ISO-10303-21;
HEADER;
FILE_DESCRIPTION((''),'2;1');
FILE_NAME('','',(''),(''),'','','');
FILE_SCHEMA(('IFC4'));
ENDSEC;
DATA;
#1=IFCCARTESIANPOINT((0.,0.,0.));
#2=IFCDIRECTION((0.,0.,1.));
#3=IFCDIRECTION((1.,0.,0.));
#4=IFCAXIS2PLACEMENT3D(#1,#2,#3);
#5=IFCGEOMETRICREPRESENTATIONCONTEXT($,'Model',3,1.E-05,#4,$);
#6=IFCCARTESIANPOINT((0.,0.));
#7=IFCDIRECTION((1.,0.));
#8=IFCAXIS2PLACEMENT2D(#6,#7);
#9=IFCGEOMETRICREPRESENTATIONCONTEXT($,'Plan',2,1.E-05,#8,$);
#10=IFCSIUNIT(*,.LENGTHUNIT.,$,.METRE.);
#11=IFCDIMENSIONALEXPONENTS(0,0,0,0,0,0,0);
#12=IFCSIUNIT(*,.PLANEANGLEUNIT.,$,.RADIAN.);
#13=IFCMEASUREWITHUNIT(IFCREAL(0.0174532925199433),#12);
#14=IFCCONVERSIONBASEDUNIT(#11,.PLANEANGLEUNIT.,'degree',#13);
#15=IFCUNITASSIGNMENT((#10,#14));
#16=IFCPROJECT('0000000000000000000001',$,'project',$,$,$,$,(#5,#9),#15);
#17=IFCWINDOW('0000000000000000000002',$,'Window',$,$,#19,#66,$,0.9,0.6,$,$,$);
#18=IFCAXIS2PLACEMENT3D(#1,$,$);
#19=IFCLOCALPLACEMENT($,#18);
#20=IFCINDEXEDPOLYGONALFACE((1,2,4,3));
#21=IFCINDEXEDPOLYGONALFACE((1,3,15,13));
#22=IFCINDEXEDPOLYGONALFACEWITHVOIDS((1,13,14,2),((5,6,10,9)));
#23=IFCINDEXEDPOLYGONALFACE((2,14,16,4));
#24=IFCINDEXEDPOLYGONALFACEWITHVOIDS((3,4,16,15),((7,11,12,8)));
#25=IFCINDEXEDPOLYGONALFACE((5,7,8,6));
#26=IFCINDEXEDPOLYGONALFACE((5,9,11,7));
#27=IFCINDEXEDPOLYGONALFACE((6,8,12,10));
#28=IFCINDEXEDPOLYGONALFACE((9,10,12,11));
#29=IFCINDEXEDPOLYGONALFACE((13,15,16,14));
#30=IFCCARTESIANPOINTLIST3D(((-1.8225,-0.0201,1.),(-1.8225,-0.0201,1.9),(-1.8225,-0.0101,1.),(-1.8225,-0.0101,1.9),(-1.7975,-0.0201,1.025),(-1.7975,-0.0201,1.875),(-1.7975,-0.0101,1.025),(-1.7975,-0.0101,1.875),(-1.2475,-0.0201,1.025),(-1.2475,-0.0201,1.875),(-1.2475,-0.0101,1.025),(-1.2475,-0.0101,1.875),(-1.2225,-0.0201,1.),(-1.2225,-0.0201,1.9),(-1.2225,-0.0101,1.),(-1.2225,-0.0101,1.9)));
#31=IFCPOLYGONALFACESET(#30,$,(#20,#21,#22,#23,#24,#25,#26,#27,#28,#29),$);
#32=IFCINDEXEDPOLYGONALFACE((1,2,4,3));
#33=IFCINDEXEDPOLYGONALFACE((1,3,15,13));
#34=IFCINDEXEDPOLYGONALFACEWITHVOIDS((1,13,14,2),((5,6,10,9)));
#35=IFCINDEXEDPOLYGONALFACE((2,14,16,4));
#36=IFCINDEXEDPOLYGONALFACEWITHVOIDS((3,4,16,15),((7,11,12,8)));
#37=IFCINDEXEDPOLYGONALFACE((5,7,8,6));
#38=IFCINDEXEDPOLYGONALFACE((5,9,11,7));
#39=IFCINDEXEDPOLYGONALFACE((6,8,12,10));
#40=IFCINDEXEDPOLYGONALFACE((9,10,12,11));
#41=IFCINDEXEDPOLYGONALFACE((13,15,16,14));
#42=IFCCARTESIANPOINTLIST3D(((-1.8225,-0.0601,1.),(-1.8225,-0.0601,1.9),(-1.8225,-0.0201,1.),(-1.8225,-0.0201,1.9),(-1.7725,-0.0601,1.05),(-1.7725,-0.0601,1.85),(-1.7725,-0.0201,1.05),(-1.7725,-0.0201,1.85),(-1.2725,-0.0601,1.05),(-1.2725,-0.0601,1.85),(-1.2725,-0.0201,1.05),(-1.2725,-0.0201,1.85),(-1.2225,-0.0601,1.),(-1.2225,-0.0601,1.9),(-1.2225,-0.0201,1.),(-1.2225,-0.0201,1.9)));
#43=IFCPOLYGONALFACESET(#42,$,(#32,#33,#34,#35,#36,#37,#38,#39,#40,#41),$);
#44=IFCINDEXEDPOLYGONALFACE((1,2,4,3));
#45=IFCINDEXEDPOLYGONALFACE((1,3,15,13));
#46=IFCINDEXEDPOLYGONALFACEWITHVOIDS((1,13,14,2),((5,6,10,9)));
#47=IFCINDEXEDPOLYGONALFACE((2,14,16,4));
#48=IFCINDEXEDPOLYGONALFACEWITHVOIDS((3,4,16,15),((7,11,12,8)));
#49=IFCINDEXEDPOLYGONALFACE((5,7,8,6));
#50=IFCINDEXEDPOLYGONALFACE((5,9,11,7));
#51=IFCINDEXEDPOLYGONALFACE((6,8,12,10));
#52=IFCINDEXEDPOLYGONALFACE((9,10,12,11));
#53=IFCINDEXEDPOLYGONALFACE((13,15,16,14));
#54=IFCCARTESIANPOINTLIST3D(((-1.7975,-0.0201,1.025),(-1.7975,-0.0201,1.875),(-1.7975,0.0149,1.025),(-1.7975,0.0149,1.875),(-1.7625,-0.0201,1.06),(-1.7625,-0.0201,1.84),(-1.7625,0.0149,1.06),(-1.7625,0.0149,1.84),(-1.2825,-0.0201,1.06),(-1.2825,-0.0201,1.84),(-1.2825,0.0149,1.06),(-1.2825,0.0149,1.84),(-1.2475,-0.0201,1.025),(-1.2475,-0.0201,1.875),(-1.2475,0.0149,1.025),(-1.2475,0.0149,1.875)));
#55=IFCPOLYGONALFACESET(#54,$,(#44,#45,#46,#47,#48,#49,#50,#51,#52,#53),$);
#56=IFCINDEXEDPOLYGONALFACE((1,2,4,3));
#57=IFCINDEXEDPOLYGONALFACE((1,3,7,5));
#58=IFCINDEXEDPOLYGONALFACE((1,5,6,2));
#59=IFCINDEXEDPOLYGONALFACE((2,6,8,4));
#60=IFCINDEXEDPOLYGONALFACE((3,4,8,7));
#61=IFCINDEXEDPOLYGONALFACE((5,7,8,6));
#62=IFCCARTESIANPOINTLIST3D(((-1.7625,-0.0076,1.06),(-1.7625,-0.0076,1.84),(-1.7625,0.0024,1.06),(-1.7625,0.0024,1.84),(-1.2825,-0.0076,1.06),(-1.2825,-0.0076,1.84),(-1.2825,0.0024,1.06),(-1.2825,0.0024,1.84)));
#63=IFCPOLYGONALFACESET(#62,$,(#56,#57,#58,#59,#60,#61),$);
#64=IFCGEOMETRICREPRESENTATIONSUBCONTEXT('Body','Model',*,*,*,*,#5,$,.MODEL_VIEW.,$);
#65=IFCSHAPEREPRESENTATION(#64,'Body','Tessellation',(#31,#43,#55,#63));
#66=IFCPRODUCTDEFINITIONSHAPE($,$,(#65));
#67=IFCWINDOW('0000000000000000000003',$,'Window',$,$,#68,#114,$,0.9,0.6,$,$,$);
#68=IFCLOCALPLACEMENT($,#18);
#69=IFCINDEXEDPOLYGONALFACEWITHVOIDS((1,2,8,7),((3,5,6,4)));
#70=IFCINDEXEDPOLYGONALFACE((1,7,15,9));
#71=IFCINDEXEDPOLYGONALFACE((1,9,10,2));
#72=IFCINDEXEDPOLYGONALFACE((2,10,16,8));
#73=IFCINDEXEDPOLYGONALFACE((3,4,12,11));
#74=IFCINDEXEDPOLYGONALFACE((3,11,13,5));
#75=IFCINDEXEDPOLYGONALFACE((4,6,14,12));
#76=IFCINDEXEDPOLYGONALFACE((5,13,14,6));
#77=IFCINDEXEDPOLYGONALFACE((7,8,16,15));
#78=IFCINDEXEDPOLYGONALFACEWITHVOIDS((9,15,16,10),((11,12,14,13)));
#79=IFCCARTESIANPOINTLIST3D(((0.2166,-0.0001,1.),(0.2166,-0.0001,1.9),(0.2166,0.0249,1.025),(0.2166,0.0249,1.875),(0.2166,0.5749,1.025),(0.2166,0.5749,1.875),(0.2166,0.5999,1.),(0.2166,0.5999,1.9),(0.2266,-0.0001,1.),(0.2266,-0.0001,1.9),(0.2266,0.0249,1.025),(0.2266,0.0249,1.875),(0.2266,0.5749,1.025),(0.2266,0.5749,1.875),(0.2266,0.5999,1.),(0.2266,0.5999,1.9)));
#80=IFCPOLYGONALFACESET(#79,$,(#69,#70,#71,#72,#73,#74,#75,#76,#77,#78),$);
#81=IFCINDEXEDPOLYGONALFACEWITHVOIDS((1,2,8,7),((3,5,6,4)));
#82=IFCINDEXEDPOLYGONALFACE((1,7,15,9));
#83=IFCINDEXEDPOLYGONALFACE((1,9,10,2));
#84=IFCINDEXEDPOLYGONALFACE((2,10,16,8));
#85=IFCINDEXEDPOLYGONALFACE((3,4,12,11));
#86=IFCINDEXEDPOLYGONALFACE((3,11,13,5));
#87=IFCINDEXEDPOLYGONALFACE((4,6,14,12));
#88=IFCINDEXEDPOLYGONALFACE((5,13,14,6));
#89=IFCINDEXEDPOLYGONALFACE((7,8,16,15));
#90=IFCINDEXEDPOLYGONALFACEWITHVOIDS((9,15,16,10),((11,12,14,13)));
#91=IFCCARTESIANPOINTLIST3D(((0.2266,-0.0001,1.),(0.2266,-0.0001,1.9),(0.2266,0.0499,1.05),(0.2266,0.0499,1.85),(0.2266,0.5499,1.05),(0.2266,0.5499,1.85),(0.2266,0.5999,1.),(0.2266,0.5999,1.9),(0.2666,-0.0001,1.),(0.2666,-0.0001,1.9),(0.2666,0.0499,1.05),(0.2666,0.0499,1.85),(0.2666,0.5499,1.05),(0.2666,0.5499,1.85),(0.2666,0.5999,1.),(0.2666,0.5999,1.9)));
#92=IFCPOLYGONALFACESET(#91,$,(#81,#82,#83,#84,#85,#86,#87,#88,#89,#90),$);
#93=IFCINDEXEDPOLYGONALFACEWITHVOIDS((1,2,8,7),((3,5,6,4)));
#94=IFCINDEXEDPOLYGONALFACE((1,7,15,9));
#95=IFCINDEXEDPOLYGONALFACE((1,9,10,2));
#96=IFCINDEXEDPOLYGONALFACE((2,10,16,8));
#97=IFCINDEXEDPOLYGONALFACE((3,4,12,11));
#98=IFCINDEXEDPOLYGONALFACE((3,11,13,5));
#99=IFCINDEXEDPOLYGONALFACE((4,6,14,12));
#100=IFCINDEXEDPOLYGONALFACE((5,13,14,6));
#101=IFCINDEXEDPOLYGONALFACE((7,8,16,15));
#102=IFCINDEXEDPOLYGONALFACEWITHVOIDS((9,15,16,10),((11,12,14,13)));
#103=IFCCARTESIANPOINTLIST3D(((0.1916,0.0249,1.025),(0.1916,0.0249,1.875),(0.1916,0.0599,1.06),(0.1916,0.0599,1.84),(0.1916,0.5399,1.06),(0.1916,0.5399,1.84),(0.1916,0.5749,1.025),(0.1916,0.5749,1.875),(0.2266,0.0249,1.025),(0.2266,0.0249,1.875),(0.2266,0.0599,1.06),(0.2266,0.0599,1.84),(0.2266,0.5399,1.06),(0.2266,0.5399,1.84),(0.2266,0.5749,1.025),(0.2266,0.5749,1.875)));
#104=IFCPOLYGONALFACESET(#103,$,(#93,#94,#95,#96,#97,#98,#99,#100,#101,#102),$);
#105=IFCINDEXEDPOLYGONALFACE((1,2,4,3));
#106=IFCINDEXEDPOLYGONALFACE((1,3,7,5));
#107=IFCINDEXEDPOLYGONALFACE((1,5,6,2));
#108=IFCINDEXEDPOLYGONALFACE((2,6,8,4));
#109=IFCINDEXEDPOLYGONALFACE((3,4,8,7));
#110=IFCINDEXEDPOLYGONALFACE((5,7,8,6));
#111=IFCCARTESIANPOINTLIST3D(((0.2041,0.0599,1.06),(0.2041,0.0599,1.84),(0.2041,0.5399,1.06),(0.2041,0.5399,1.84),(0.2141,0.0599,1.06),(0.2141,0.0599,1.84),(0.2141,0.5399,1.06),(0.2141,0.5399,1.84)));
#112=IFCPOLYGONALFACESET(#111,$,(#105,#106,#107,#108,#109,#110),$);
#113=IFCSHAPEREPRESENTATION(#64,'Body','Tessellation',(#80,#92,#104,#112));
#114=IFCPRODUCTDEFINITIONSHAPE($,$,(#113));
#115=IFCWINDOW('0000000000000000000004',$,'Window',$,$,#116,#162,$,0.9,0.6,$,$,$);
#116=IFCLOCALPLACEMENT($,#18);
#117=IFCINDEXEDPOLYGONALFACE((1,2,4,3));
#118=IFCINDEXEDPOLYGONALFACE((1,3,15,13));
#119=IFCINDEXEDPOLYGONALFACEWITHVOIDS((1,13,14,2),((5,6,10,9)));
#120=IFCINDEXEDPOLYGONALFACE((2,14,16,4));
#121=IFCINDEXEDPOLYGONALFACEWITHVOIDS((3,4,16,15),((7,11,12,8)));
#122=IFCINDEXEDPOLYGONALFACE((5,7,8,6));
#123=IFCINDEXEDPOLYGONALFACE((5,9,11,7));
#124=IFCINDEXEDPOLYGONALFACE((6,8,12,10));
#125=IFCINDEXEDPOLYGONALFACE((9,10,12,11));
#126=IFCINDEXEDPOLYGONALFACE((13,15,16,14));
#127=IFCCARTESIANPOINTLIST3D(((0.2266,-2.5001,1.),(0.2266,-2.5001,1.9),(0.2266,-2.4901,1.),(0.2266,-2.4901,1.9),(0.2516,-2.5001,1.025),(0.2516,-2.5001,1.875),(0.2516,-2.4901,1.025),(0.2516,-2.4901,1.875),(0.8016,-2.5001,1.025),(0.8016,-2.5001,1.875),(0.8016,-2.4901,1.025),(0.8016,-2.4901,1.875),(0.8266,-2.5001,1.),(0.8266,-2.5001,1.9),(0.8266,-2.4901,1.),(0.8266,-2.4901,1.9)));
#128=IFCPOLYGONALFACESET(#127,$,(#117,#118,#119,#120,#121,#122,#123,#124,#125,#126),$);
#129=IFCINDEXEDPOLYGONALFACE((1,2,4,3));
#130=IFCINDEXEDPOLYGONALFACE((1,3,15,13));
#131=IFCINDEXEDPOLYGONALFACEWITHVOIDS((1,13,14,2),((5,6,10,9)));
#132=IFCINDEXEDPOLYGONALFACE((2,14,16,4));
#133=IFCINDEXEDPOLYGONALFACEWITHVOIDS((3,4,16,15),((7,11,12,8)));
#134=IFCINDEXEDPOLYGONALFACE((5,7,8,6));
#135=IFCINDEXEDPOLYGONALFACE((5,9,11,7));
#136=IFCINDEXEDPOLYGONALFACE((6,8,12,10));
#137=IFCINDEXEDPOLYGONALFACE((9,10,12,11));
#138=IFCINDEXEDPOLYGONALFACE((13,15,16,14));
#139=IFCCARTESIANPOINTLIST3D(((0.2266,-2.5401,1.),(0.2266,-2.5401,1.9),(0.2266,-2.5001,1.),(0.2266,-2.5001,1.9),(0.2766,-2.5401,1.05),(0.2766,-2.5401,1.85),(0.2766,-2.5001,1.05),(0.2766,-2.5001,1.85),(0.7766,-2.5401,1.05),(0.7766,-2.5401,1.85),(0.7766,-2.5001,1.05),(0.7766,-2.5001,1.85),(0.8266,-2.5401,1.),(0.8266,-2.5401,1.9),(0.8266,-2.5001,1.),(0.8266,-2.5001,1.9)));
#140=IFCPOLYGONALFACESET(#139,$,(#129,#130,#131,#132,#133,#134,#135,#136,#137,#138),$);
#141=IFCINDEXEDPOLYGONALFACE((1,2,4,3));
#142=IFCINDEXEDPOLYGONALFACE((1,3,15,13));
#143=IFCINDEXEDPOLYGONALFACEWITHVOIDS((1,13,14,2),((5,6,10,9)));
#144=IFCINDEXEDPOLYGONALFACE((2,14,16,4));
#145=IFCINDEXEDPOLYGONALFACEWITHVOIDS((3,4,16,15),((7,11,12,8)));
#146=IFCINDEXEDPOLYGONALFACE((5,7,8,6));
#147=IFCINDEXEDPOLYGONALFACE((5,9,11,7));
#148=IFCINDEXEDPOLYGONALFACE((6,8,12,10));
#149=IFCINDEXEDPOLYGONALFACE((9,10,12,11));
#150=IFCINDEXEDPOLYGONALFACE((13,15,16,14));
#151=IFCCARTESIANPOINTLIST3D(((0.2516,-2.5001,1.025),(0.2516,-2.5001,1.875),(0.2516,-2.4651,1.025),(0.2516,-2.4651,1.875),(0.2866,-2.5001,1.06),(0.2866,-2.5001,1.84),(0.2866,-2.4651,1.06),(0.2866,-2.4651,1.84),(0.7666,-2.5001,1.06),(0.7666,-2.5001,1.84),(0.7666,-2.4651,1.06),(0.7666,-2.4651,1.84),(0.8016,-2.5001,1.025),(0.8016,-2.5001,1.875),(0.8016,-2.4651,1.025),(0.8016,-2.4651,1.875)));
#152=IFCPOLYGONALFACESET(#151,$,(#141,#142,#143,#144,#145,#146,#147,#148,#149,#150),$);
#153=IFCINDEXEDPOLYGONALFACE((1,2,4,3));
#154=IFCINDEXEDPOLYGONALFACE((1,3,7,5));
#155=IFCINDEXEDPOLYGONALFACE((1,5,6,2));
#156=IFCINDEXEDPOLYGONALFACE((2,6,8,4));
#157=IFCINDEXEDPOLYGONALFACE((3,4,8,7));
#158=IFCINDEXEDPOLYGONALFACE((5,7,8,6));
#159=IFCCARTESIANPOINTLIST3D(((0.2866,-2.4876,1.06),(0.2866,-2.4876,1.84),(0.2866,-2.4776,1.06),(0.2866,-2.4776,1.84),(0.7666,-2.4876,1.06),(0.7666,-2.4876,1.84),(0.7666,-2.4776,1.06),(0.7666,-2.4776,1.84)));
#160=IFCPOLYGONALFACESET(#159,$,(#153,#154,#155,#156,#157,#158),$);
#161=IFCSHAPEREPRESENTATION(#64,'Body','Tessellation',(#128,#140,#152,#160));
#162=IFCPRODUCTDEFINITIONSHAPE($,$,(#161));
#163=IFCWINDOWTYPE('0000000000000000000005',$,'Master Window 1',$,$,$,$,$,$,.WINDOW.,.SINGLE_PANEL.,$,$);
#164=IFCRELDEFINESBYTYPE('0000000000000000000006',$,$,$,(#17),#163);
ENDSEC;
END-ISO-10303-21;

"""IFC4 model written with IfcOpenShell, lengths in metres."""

from ifc_helpers import new_model, entity, si_unit, converted_unit, frame, origin_with_axes, origin_2d_with_axis, place, context, subcontext, project, line, indexed_curve, outline, extrude, shape, source, transform, mapped, type_object, type_shapes, element, save


model = new_model("IFC4")

# Units and contexts
model_context = context("Model", 3, precision=1e-05, world=origin_with_axes())
plan_context = context("Plan", 2, precision=1e-05, world=origin_2d_with_axis())
body_context_1 = subcontext(model_context, "Body", "Model", "MODEL_VIEW")
body_context_2 = subcontext(plan_context, "Body", "Plan", "PLAN_VIEW")
ifc_project = project(units=[si_unit("LENGTHUNIT", "METRE"), converted_unit("PLANEANGLEUNIT", "degree", entity("IfcReal", 0.0174532925199433), si_unit("PLANEANGLEUNIT", "RADIAN"), dimensions=[0, 0, 0, 0, 0, 0, 0])], contexts=[model_context, plan_context])

# Windows
window_type = type_object("IfcWindowType", Name="Master Window 1", PartitioningType="SINGLE_PANEL", PredefinedType="WINDOW")
shared_shape_1 = source(origin_with_axes(), body_context_1, "Body", "SweptSolid", [
    extrude(outline(indexed_curve([(0.0, 0.0), (0.6, 0.0), (0.6, 0.9), (0.0, 0.9)], segments=[line(1, 2, 3, 4, 1)]), holes=[indexed_curve([(0.025, 0.025), (0.575, 0.025), (0.575, 0.875), (0.025, 0.875)], segments=[line(1, 2, 3, 4, 1)])]), frame((0.0, 0.09, 0.0), z_axis=(0.0, -1.0, 0.0), x_axis=(1.0, 0.0, 0.0)), (0.0, 0.0, -1.0), 0.01),
    extrude(outline(indexed_curve([(0.0, 0.0), (0.6, 0.0), (0.6, 0.9), (0.0, 0.9)], segments=[line(1, 2, 3, 4, 1)]), holes=[indexed_curve([(0.05, 0.05), (0.55, 0.05), (0.55, 0.85), (0.05, 0.85)], segments=[line(1, 2, 3, 4, 1)])]), frame((0.0, 0.05, 0.0), z_axis=(0.0, -1.0, 0.0), x_axis=(1.0, 0.0, 0.0)), (0.0, 0.0, -1.0), 0.04),
    extrude(outline(indexed_curve([(0.0, 0.0), (0.55, 0.0), (0.55, 0.85), (0.0, 0.85)], segments=[line(1, 2, 3, 4, 1)]), holes=[indexed_curve([(0.035, 0.035), (0.515, 0.035), (0.515, 0.815), (0.035, 0.815)], segments=[line(1, 2, 3, 4, 1)])]), frame((0.025, 0.09, 0.025), z_axis=(0.0, -1.0, 0.0), x_axis=(1.0, 0.0, 0.0)), (0.0, 0.0, -1.0), 0.035),
    extrude(outline(indexed_curve([(0.035, 0.035), (0.515, 0.035), (0.515, 0.815), (0.035, 0.815)], segments=[line(1, 2, 3, 4, 1)])), frame((0.025, 0.1025, 0.025), z_axis=(0.0, -1.0, 0.0), x_axis=(1.0, 0.0, 0.0)), (0.0, 0.0, -1.0), 0.01),
])
shared_shape_2 = source(origin_with_axes(), body_context_2, "Body", "Curve2D", [
    entity("IfcIndexedPolyCurve", entity("IfcCartesianPointList2D", [[0.05, 0.05], [0.55, 0.05]])),
    entity("IfcIndexedPolyCurve", entity("IfcCartesianPointList2D", [[0.0, 0.1], [0.025, 0.1], [0.025, 0.09], [0.05, 0.09], [0.05, 0.05], [0.0, 0.05]]), [entity("IfcLineIndex", [1, 2, 3, 4, 5, 6, 1])]),
    entity("IfcIndexedPolyCurve", entity("IfcCartesianPointList2D", [[0.6, 0.1], [0.575, 0.1], [0.575, 0.09], [0.55, 0.09], [0.55, 0.05], [0.6, 0.05]]), [entity("IfcLineIndex", [1, 2, 3, 4, 5, 6, 1])]),
    entity("IfcIndexedPolyCurve", entity("IfcCartesianPointList2D", [[0.025, 0.09], [0.06, 0.09], [0.06, 0.125], [0.025, 0.125]]), [entity("IfcLineIndex", [1, 2, 3, 4, 1])]),
    entity("IfcIndexedPolyCurve", entity("IfcCartesianPointList2D", [[0.575, 0.09], [0.54, 0.09], [0.54, 0.125], [0.575, 0.125]]), [entity("IfcLineIndex", [1, 2, 3, 4, 1])]),
    entity("IfcIndexedPolyCurve", entity("IfcCartesianPointList2D", [[0.06, 0.09], [0.54, 0.09]])),
    entity("IfcIndexedPolyCurve", entity("IfcCartesianPointList2D", [[0.06, 0.125], [0.54, 0.125]])),
    entity("IfcIndexedPolyCurve", entity("IfcCartesianPointList2D", [[0.06, 0.1075], [0.54, 0.1075]])),
])
type_shapes(window_type, [shared_shape_1, shared_shape_2])
placement_1 = place(None, origin_with_axes())
placement_2 = place(placement_1, origin_with_axes())
placement_3 = place(placement_2, origin_with_axes())
placement_4 = place(placement_3, frame((-2.7734, -0.1101, 0.0), z_axis=(0.0, 0.0, 1.0), x_axis=(1.0, 0.0, 0.0)))
placement_5 = place(placement_4, frame((0.9509, 0.0, 1.0), z_axis=(0.0, 0.0, 1.0), x_axis=(1.0, 0.0, 0.0)))
window_1_placement = place(placement_5, origin_with_axes())
element("IfcWindow", 1, at=window_1_placement, type_object=window_type, Name="Window", OverallHeight=0.9, OverallWidth=0.6, shapes=[
    shape(body_context_1, "Body", "MappedRepresentation", [mapped(shared_shape_1, transform((0.0, 0.0, 0.0), x_axis=(1.0, 0.0, 0.0), y_axis=(0.0, 1.0, 0.0), z_axis=(0.0, 0.0, 1.0), scale=1.0))]),
    shape(body_context_2, "Body", "MappedRepresentation", [mapped(shared_shape_2, transform((0.0, 0.0, 0.0), x_axis=(1.0, 0.0, 0.0), y_axis=(0.0, 1.0, 0.0), z_axis=(0.0, 0.0, 1.0), scale=1.0))]),
])
placement_6 = place(placement_3, frame((0.3166, -0.0001, 0.0), z_axis=(0.0, 0.0, 1.0), x_axis=(0.0, 1.0, 0.0)))
placement_7 = place(placement_6, frame((0.0, 0.0, 1.0), z_axis=(0.0, 0.0, 1.0), x_axis=(1.0, 0.0, 0.0)))
window_2_placement = place(placement_7, frame((0.0, 0.0, 0.0), z_axis=(0.0, 0.0, 1.0), x_axis=(1.0, 0.0, 0.0)))
element("IfcWindow", 2, at=window_2_placement, Name="Window", OverallHeight=0.9, OverallWidth=0.6, shapes=[
    shape(body_context_1, "Body", "MappedRepresentation", [mapped(shared_shape_1, transform((0.0, 0.0, 0.0), x_axis=(1.0, 0.0, 0.0), y_axis=(0.0, 1.0, 0.0), z_axis=(0.0, 0.0, 1.0), scale=1.0))]),
    shape(body_context_2, "Body", "MappedRepresentation", [mapped(shared_shape_2, transform((0.0, 0.0, 0.0), x_axis=(1.0, 0.0, 0.0), y_axis=(0.0, 1.0, 0.0), z_axis=(0.0, 0.0, 1.0), scale=1.0))]),
])
placement_8 = place(placement_3, frame((0.2266, -2.5901, 0.0), z_axis=(0.0, 0.0, 1.0), x_axis=(1.0, 0.0, 0.0)))
placement_9 = place(placement_8, frame((0.0, 0.0, 1.0), z_axis=(0.0, 0.0, 1.0), x_axis=(1.0, 0.0, 0.0)))
window_3_placement = place(placement_9, origin_with_axes())
element("IfcWindow", 3, at=window_3_placement, Name="Window", OverallHeight=0.9, OverallWidth=0.6, shapes=[
    shape(body_context_1, "Body", "MappedRepresentation", [mapped(shared_shape_1, transform((0.0, 0.0, 0.0), x_axis=(1.0, 0.0, 0.0), y_axis=(0.0, 1.0, 0.0), z_axis=(0.0, 0.0, 1.0), scale=1.0))]),
    shape(body_context_2, "Body", "MappedRepresentation", [mapped(shared_shape_2, transform((0.0, 0.0, 0.0), x_axis=(1.0, 0.0, 0.0), y_axis=(0.0, 1.0, 0.0), z_axis=(0.0, 0.0, 1.0), scale=1.0))]),
])

save(model, "model.ifc")
